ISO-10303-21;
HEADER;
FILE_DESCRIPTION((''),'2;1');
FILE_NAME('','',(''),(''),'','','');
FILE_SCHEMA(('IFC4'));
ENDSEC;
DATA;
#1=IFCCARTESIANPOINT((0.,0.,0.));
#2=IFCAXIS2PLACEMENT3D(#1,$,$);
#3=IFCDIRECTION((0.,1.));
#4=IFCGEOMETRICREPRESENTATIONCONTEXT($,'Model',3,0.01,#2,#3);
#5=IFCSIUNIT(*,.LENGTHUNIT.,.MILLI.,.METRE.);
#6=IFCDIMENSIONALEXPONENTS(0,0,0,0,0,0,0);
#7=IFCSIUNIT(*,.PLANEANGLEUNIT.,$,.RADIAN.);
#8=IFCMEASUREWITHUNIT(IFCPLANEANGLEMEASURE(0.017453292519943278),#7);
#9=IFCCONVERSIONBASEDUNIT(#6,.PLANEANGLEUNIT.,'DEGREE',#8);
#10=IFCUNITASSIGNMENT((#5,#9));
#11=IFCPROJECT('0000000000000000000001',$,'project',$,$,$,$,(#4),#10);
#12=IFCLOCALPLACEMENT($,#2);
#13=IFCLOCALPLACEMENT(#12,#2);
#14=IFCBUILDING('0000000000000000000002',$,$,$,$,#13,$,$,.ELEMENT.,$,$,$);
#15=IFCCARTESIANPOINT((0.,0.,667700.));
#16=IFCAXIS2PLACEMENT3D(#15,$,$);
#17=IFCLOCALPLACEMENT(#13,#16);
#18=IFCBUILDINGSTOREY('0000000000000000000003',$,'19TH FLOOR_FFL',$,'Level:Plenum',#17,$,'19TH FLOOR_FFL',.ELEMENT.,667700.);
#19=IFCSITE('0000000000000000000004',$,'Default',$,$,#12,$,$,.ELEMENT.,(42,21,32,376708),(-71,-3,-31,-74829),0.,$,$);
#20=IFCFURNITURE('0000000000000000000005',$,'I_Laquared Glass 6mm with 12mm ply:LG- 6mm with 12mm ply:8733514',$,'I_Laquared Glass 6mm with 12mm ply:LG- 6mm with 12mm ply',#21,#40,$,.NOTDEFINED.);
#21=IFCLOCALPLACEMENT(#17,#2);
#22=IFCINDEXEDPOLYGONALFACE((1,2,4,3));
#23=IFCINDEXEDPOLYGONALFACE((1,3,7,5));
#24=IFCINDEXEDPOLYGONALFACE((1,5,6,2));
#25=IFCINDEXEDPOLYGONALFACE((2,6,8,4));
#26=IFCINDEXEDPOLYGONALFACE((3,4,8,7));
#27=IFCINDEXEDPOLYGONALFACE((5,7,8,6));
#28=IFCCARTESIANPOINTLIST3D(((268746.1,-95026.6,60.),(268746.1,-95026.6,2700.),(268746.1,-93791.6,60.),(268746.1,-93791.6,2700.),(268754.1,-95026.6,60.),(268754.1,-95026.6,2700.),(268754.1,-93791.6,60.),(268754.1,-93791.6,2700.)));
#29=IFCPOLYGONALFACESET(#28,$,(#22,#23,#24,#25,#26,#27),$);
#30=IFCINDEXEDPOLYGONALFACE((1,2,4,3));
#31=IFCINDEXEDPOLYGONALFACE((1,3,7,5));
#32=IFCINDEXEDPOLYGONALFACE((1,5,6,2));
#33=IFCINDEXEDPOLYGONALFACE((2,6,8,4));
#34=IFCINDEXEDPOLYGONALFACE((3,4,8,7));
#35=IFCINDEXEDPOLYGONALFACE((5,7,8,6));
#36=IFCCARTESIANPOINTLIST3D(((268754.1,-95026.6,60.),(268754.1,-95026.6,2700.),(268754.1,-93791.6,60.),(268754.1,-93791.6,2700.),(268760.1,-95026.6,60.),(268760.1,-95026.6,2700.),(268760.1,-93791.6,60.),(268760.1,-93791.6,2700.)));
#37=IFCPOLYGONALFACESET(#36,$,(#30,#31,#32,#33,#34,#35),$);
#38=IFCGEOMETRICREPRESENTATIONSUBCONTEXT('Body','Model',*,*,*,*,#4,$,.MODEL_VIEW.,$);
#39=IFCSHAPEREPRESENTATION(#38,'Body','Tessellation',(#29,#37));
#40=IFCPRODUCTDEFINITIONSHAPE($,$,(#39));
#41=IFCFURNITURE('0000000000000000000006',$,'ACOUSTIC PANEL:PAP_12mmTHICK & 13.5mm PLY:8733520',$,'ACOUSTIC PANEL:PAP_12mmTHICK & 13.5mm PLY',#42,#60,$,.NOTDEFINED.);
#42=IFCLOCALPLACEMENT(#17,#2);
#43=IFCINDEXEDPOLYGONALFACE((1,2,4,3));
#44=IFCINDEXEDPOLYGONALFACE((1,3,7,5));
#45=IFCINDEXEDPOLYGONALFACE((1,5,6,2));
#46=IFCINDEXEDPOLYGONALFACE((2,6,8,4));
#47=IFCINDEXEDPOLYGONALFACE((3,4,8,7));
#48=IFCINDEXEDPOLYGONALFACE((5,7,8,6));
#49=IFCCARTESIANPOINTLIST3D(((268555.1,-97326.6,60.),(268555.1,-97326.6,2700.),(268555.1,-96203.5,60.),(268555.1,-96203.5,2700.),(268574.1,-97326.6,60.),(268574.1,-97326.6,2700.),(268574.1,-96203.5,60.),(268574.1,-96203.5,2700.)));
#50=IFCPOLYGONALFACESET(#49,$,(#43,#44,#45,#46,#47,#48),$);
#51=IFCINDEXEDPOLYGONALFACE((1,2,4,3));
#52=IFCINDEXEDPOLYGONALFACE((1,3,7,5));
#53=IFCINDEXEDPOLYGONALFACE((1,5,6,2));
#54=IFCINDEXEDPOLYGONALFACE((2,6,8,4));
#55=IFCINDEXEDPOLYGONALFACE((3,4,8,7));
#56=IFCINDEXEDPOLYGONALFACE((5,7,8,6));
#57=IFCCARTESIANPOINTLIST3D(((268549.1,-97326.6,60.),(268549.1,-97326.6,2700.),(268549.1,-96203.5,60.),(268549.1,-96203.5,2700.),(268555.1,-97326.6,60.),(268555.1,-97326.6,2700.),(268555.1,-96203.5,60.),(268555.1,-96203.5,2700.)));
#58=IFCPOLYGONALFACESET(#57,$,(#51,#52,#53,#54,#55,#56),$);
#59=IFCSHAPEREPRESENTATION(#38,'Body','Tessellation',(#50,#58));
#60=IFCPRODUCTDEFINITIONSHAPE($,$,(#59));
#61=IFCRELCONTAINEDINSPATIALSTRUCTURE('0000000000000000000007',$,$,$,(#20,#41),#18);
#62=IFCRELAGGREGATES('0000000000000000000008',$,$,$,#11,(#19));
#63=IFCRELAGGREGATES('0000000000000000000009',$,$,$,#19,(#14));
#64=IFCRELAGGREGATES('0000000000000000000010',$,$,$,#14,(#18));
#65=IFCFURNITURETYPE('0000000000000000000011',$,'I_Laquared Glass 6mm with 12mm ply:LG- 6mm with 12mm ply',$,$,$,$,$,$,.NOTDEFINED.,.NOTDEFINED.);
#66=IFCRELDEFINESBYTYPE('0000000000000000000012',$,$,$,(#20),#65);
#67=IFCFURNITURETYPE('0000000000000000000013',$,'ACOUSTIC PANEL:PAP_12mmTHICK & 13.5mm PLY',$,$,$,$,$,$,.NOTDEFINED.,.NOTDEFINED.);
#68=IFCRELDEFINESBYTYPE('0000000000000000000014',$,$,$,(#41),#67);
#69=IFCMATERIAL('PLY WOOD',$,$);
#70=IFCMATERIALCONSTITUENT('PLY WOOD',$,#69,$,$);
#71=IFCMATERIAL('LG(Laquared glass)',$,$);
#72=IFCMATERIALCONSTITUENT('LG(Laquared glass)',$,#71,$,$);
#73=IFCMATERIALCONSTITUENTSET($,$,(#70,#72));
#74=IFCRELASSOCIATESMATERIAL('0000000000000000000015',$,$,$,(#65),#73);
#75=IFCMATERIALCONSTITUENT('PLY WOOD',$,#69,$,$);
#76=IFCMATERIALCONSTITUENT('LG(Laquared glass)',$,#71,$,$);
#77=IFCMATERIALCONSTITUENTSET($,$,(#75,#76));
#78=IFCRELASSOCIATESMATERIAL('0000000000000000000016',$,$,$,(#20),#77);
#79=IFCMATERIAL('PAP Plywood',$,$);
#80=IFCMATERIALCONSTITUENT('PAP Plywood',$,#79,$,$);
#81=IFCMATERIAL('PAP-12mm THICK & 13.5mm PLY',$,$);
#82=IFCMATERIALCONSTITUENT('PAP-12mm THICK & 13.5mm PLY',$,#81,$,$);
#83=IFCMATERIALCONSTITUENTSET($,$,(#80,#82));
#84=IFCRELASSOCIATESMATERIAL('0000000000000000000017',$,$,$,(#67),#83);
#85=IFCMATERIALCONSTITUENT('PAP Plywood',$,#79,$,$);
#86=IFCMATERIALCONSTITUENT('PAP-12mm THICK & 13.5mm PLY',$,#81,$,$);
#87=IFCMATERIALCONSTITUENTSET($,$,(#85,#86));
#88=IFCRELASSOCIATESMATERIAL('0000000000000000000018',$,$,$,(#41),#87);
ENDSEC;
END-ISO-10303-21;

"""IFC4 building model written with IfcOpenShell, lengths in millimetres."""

from ifc_helpers import new_model, entity, si_unit, converted_unit, direction, frame, origin, place, context, subcontext, project, spatial, indexed_curve, outline, extrude, source, transform, mapped, material, constituent, constituent_set, type_object, type_shapes, element, save


model = new_model("IFC4")

# Units and contexts
model_context = context("Model", 3, precision=0.01, world=origin(), true_north=direction((0.0, 1.0)))
body_context = subcontext(model_context, "Body", "Model", "MODEL_VIEW")
ifc_project = project(units=[si_unit("LENGTHUNIT", "METRE", prefix="MILLI"), converted_unit("PLANEANGLEUNIT", "DEGREE", entity("IfcPlaneAngleMeasure", 0.017453292519943278), si_unit("PLANEANGLEUNIT", "RADIAN"), dimensions=[0, 0, 0, 0, 0, 0, 0])], contexts=[model_context])

# Site, building, storey
site_placement = place(None, origin())
site = spatial("IfcSite", under=ifc_project, at=site_placement, Name="Default", CompositionType="ELEMENT", RefLatitude=(42, 21, 32, 376708), RefLongitude=(-71, -3, -31, -74829), RefElevation=0.0)
building_placement = place(site_placement, origin())
building = spatial("IfcBuilding", under=site, at=building_placement, CompositionType="ELEMENT")
storey_placement = place(building_placement, frame((0.0, 0.0, 667700.0)))
storey = spatial("IfcBuildingStorey", under=building, at=storey_placement, Name="19TH FLOOR_FFL", ObjectType="Level:Plenum", LongName="19TH FLOOR_FFL", CompositionType="ELEMENT", Elevation=667700.0)

# Furniture
ifc_material_1 = material(Name="PLY WOOD")
ifc_material_2 = material(Name="LG(Laquared glass)")
ifc_constituent_1 = constituent(ifc_material_1, Name="PLY WOOD")
ifc_constituent_2 = constituent(ifc_material_2, Name="LG(Laquared glass)")
ifc_constituent_set_1 = constituent_set(constituents=[ifc_constituent_1, ifc_constituent_2])
ifc_constituent_3 = constituent(ifc_material_1, Name="PLY WOOD")
ifc_constituent_4 = constituent(ifc_material_2, Name="LG(Laquared glass)")
ifc_constituent_set_2 = constituent_set(constituents=[ifc_constituent_3, ifc_constituent_4])
furniture_type_1 = type_object("IfcFurnitureType", Name="I_Laquared Glass 6mm with 12mm ply:LG- 6mm with 12mm ply", AssemblyPlace="NOTDEFINED", PredefinedType="NOTDEFINED", material=ifc_constituent_set_2)
shared_shape_1 = source(origin(), body_context, "Body", "SweptSolid", [
    extrude(outline(indexed_curve([(-617.5, -1320.0), (617.5, -1320.0), (617.5, 1320.0), (-617.5, 1320.0), (-617.5, -1320.0)], self_intersect=False)), frame((0.0, 1320.0, 0.0), z_axis=(0.0, 0.0, 1.0), x_axis=(-1.0, 0.0, 0.0)), (0.0, 0.0, 1.0), 8.0),
    extrude(outline(indexed_curve([(-617.5, -1320.0), (617.5, -1320.0), (617.5, 1320.0), (-617.5, 1320.0), (-617.5, -1320.0)], self_intersect=False)), frame((0.0, 1320.0, 8.0), z_axis=(0.0, 0.0, 1.0), x_axis=(-1.0, 0.0, 0.0)), (0.0, 0.0, 1.0), 6.0),
])
type_shapes(furniture_type_1, [shared_shape_1])
furniture_1_placement = place(storey_placement, frame((268746.1, -94409.1, 60.0), z_axis=(1.0, 0.0, 0.0), x_axis=(0.0, 1.0, 0.0)))
element("IfcFurniture", 1, at=furniture_1_placement, inside=storey, type_object=furniture_type_1, material=ifc_constituent_set_1, Name="I_Laquared Glass 6mm with 12mm ply:LG- 6mm with 12mm ply:8733514", ObjectType="I_Laquared Glass 6mm with 12mm ply:LG- 6mm with 12mm ply", PredefinedType="NOTDEFINED", context=body_context, shape_type="MappedRepresentation", body=[
    mapped(shared_shape_1, transform((0.0, 0.0, 0.0), scale=1.0)),
])
ifc_material_3 = material(Name="PAP Plywood")
ifc_constituent_5 = constituent(ifc_material_3, Name="PAP Plywood")
ifc_material_4 = material(Name="PAP-12mm THICK & 13.5mm PLY")
ifc_constituent_6 = constituent(ifc_material_4, Name="PAP-12mm THICK & 13.5mm PLY")
ifc_constituent_set_3 = constituent_set(constituents=[ifc_constituent_5, ifc_constituent_6])
ifc_constituent_7 = constituent(ifc_material_3, Name="PAP Plywood")
ifc_constituent_8 = constituent(ifc_material_4, Name="PAP-12mm THICK & 13.5mm PLY")
ifc_constituent_set_4 = constituent_set(constituents=[ifc_constituent_7, ifc_constituent_8])
furniture_type_2 = type_object("IfcFurnitureType", Name="ACOUSTIC PANEL:PAP_12mmTHICK & 13.5mm PLY", AssemblyPlace="NOTDEFINED", PredefinedType="NOTDEFINED", material=ifc_constituent_set_4)
shared_shape_2 = source(origin(), body_context, "Body", "SweptSolid", [
    extrude(outline(indexed_curve([(-561.6, -1320.0), (561.6, -1320.0), (561.6, 1320.0), (-561.6, 1320.0), (-561.6, -1320.0)], self_intersect=False)), frame((0.0, 1320.0, 0.0), z_axis=(0.0, 0.0, 1.0), x_axis=(-1.0, 0.0, 0.0)), (0.0, 0.0, 1.0), 19.0),
    extrude(outline(indexed_curve([(-561.6, -1320.0), (561.6, -1320.0), (561.6, 1320.0), (-561.6, 1320.0), (-561.6, -1320.0)], self_intersect=False)), frame((0.0, 1320.0, 19.0), z_axis=(0.0, 0.0, 1.0), x_axis=(-1.0, 0.0, 0.0)), (0.0, 0.0, 1.0), 6.0),
])
type_shapes(furniture_type_2, [shared_shape_2])
furniture_2_placement = place(storey_placement, frame((268574.1, -96765.1, 60.0), z_axis=(-1.0, 0.0, 0.0), x_axis=(0.0, -1.0, 0.0)))
element("IfcFurniture", 2, at=furniture_2_placement, inside=storey, type_object=furniture_type_2, material=ifc_constituent_set_3, Name="ACOUSTIC PANEL:PAP_12mmTHICK & 13.5mm PLY:8733520", ObjectType="ACOUSTIC PANEL:PAP_12mmTHICK & 13.5mm PLY", PredefinedType="NOTDEFINED", context=body_context, shape_type="MappedRepresentation", body=[
    mapped(shared_shape_2, transform((0.0, 0.0, 0.0), scale=1.0)),
])

save(model, "model.ifc")
